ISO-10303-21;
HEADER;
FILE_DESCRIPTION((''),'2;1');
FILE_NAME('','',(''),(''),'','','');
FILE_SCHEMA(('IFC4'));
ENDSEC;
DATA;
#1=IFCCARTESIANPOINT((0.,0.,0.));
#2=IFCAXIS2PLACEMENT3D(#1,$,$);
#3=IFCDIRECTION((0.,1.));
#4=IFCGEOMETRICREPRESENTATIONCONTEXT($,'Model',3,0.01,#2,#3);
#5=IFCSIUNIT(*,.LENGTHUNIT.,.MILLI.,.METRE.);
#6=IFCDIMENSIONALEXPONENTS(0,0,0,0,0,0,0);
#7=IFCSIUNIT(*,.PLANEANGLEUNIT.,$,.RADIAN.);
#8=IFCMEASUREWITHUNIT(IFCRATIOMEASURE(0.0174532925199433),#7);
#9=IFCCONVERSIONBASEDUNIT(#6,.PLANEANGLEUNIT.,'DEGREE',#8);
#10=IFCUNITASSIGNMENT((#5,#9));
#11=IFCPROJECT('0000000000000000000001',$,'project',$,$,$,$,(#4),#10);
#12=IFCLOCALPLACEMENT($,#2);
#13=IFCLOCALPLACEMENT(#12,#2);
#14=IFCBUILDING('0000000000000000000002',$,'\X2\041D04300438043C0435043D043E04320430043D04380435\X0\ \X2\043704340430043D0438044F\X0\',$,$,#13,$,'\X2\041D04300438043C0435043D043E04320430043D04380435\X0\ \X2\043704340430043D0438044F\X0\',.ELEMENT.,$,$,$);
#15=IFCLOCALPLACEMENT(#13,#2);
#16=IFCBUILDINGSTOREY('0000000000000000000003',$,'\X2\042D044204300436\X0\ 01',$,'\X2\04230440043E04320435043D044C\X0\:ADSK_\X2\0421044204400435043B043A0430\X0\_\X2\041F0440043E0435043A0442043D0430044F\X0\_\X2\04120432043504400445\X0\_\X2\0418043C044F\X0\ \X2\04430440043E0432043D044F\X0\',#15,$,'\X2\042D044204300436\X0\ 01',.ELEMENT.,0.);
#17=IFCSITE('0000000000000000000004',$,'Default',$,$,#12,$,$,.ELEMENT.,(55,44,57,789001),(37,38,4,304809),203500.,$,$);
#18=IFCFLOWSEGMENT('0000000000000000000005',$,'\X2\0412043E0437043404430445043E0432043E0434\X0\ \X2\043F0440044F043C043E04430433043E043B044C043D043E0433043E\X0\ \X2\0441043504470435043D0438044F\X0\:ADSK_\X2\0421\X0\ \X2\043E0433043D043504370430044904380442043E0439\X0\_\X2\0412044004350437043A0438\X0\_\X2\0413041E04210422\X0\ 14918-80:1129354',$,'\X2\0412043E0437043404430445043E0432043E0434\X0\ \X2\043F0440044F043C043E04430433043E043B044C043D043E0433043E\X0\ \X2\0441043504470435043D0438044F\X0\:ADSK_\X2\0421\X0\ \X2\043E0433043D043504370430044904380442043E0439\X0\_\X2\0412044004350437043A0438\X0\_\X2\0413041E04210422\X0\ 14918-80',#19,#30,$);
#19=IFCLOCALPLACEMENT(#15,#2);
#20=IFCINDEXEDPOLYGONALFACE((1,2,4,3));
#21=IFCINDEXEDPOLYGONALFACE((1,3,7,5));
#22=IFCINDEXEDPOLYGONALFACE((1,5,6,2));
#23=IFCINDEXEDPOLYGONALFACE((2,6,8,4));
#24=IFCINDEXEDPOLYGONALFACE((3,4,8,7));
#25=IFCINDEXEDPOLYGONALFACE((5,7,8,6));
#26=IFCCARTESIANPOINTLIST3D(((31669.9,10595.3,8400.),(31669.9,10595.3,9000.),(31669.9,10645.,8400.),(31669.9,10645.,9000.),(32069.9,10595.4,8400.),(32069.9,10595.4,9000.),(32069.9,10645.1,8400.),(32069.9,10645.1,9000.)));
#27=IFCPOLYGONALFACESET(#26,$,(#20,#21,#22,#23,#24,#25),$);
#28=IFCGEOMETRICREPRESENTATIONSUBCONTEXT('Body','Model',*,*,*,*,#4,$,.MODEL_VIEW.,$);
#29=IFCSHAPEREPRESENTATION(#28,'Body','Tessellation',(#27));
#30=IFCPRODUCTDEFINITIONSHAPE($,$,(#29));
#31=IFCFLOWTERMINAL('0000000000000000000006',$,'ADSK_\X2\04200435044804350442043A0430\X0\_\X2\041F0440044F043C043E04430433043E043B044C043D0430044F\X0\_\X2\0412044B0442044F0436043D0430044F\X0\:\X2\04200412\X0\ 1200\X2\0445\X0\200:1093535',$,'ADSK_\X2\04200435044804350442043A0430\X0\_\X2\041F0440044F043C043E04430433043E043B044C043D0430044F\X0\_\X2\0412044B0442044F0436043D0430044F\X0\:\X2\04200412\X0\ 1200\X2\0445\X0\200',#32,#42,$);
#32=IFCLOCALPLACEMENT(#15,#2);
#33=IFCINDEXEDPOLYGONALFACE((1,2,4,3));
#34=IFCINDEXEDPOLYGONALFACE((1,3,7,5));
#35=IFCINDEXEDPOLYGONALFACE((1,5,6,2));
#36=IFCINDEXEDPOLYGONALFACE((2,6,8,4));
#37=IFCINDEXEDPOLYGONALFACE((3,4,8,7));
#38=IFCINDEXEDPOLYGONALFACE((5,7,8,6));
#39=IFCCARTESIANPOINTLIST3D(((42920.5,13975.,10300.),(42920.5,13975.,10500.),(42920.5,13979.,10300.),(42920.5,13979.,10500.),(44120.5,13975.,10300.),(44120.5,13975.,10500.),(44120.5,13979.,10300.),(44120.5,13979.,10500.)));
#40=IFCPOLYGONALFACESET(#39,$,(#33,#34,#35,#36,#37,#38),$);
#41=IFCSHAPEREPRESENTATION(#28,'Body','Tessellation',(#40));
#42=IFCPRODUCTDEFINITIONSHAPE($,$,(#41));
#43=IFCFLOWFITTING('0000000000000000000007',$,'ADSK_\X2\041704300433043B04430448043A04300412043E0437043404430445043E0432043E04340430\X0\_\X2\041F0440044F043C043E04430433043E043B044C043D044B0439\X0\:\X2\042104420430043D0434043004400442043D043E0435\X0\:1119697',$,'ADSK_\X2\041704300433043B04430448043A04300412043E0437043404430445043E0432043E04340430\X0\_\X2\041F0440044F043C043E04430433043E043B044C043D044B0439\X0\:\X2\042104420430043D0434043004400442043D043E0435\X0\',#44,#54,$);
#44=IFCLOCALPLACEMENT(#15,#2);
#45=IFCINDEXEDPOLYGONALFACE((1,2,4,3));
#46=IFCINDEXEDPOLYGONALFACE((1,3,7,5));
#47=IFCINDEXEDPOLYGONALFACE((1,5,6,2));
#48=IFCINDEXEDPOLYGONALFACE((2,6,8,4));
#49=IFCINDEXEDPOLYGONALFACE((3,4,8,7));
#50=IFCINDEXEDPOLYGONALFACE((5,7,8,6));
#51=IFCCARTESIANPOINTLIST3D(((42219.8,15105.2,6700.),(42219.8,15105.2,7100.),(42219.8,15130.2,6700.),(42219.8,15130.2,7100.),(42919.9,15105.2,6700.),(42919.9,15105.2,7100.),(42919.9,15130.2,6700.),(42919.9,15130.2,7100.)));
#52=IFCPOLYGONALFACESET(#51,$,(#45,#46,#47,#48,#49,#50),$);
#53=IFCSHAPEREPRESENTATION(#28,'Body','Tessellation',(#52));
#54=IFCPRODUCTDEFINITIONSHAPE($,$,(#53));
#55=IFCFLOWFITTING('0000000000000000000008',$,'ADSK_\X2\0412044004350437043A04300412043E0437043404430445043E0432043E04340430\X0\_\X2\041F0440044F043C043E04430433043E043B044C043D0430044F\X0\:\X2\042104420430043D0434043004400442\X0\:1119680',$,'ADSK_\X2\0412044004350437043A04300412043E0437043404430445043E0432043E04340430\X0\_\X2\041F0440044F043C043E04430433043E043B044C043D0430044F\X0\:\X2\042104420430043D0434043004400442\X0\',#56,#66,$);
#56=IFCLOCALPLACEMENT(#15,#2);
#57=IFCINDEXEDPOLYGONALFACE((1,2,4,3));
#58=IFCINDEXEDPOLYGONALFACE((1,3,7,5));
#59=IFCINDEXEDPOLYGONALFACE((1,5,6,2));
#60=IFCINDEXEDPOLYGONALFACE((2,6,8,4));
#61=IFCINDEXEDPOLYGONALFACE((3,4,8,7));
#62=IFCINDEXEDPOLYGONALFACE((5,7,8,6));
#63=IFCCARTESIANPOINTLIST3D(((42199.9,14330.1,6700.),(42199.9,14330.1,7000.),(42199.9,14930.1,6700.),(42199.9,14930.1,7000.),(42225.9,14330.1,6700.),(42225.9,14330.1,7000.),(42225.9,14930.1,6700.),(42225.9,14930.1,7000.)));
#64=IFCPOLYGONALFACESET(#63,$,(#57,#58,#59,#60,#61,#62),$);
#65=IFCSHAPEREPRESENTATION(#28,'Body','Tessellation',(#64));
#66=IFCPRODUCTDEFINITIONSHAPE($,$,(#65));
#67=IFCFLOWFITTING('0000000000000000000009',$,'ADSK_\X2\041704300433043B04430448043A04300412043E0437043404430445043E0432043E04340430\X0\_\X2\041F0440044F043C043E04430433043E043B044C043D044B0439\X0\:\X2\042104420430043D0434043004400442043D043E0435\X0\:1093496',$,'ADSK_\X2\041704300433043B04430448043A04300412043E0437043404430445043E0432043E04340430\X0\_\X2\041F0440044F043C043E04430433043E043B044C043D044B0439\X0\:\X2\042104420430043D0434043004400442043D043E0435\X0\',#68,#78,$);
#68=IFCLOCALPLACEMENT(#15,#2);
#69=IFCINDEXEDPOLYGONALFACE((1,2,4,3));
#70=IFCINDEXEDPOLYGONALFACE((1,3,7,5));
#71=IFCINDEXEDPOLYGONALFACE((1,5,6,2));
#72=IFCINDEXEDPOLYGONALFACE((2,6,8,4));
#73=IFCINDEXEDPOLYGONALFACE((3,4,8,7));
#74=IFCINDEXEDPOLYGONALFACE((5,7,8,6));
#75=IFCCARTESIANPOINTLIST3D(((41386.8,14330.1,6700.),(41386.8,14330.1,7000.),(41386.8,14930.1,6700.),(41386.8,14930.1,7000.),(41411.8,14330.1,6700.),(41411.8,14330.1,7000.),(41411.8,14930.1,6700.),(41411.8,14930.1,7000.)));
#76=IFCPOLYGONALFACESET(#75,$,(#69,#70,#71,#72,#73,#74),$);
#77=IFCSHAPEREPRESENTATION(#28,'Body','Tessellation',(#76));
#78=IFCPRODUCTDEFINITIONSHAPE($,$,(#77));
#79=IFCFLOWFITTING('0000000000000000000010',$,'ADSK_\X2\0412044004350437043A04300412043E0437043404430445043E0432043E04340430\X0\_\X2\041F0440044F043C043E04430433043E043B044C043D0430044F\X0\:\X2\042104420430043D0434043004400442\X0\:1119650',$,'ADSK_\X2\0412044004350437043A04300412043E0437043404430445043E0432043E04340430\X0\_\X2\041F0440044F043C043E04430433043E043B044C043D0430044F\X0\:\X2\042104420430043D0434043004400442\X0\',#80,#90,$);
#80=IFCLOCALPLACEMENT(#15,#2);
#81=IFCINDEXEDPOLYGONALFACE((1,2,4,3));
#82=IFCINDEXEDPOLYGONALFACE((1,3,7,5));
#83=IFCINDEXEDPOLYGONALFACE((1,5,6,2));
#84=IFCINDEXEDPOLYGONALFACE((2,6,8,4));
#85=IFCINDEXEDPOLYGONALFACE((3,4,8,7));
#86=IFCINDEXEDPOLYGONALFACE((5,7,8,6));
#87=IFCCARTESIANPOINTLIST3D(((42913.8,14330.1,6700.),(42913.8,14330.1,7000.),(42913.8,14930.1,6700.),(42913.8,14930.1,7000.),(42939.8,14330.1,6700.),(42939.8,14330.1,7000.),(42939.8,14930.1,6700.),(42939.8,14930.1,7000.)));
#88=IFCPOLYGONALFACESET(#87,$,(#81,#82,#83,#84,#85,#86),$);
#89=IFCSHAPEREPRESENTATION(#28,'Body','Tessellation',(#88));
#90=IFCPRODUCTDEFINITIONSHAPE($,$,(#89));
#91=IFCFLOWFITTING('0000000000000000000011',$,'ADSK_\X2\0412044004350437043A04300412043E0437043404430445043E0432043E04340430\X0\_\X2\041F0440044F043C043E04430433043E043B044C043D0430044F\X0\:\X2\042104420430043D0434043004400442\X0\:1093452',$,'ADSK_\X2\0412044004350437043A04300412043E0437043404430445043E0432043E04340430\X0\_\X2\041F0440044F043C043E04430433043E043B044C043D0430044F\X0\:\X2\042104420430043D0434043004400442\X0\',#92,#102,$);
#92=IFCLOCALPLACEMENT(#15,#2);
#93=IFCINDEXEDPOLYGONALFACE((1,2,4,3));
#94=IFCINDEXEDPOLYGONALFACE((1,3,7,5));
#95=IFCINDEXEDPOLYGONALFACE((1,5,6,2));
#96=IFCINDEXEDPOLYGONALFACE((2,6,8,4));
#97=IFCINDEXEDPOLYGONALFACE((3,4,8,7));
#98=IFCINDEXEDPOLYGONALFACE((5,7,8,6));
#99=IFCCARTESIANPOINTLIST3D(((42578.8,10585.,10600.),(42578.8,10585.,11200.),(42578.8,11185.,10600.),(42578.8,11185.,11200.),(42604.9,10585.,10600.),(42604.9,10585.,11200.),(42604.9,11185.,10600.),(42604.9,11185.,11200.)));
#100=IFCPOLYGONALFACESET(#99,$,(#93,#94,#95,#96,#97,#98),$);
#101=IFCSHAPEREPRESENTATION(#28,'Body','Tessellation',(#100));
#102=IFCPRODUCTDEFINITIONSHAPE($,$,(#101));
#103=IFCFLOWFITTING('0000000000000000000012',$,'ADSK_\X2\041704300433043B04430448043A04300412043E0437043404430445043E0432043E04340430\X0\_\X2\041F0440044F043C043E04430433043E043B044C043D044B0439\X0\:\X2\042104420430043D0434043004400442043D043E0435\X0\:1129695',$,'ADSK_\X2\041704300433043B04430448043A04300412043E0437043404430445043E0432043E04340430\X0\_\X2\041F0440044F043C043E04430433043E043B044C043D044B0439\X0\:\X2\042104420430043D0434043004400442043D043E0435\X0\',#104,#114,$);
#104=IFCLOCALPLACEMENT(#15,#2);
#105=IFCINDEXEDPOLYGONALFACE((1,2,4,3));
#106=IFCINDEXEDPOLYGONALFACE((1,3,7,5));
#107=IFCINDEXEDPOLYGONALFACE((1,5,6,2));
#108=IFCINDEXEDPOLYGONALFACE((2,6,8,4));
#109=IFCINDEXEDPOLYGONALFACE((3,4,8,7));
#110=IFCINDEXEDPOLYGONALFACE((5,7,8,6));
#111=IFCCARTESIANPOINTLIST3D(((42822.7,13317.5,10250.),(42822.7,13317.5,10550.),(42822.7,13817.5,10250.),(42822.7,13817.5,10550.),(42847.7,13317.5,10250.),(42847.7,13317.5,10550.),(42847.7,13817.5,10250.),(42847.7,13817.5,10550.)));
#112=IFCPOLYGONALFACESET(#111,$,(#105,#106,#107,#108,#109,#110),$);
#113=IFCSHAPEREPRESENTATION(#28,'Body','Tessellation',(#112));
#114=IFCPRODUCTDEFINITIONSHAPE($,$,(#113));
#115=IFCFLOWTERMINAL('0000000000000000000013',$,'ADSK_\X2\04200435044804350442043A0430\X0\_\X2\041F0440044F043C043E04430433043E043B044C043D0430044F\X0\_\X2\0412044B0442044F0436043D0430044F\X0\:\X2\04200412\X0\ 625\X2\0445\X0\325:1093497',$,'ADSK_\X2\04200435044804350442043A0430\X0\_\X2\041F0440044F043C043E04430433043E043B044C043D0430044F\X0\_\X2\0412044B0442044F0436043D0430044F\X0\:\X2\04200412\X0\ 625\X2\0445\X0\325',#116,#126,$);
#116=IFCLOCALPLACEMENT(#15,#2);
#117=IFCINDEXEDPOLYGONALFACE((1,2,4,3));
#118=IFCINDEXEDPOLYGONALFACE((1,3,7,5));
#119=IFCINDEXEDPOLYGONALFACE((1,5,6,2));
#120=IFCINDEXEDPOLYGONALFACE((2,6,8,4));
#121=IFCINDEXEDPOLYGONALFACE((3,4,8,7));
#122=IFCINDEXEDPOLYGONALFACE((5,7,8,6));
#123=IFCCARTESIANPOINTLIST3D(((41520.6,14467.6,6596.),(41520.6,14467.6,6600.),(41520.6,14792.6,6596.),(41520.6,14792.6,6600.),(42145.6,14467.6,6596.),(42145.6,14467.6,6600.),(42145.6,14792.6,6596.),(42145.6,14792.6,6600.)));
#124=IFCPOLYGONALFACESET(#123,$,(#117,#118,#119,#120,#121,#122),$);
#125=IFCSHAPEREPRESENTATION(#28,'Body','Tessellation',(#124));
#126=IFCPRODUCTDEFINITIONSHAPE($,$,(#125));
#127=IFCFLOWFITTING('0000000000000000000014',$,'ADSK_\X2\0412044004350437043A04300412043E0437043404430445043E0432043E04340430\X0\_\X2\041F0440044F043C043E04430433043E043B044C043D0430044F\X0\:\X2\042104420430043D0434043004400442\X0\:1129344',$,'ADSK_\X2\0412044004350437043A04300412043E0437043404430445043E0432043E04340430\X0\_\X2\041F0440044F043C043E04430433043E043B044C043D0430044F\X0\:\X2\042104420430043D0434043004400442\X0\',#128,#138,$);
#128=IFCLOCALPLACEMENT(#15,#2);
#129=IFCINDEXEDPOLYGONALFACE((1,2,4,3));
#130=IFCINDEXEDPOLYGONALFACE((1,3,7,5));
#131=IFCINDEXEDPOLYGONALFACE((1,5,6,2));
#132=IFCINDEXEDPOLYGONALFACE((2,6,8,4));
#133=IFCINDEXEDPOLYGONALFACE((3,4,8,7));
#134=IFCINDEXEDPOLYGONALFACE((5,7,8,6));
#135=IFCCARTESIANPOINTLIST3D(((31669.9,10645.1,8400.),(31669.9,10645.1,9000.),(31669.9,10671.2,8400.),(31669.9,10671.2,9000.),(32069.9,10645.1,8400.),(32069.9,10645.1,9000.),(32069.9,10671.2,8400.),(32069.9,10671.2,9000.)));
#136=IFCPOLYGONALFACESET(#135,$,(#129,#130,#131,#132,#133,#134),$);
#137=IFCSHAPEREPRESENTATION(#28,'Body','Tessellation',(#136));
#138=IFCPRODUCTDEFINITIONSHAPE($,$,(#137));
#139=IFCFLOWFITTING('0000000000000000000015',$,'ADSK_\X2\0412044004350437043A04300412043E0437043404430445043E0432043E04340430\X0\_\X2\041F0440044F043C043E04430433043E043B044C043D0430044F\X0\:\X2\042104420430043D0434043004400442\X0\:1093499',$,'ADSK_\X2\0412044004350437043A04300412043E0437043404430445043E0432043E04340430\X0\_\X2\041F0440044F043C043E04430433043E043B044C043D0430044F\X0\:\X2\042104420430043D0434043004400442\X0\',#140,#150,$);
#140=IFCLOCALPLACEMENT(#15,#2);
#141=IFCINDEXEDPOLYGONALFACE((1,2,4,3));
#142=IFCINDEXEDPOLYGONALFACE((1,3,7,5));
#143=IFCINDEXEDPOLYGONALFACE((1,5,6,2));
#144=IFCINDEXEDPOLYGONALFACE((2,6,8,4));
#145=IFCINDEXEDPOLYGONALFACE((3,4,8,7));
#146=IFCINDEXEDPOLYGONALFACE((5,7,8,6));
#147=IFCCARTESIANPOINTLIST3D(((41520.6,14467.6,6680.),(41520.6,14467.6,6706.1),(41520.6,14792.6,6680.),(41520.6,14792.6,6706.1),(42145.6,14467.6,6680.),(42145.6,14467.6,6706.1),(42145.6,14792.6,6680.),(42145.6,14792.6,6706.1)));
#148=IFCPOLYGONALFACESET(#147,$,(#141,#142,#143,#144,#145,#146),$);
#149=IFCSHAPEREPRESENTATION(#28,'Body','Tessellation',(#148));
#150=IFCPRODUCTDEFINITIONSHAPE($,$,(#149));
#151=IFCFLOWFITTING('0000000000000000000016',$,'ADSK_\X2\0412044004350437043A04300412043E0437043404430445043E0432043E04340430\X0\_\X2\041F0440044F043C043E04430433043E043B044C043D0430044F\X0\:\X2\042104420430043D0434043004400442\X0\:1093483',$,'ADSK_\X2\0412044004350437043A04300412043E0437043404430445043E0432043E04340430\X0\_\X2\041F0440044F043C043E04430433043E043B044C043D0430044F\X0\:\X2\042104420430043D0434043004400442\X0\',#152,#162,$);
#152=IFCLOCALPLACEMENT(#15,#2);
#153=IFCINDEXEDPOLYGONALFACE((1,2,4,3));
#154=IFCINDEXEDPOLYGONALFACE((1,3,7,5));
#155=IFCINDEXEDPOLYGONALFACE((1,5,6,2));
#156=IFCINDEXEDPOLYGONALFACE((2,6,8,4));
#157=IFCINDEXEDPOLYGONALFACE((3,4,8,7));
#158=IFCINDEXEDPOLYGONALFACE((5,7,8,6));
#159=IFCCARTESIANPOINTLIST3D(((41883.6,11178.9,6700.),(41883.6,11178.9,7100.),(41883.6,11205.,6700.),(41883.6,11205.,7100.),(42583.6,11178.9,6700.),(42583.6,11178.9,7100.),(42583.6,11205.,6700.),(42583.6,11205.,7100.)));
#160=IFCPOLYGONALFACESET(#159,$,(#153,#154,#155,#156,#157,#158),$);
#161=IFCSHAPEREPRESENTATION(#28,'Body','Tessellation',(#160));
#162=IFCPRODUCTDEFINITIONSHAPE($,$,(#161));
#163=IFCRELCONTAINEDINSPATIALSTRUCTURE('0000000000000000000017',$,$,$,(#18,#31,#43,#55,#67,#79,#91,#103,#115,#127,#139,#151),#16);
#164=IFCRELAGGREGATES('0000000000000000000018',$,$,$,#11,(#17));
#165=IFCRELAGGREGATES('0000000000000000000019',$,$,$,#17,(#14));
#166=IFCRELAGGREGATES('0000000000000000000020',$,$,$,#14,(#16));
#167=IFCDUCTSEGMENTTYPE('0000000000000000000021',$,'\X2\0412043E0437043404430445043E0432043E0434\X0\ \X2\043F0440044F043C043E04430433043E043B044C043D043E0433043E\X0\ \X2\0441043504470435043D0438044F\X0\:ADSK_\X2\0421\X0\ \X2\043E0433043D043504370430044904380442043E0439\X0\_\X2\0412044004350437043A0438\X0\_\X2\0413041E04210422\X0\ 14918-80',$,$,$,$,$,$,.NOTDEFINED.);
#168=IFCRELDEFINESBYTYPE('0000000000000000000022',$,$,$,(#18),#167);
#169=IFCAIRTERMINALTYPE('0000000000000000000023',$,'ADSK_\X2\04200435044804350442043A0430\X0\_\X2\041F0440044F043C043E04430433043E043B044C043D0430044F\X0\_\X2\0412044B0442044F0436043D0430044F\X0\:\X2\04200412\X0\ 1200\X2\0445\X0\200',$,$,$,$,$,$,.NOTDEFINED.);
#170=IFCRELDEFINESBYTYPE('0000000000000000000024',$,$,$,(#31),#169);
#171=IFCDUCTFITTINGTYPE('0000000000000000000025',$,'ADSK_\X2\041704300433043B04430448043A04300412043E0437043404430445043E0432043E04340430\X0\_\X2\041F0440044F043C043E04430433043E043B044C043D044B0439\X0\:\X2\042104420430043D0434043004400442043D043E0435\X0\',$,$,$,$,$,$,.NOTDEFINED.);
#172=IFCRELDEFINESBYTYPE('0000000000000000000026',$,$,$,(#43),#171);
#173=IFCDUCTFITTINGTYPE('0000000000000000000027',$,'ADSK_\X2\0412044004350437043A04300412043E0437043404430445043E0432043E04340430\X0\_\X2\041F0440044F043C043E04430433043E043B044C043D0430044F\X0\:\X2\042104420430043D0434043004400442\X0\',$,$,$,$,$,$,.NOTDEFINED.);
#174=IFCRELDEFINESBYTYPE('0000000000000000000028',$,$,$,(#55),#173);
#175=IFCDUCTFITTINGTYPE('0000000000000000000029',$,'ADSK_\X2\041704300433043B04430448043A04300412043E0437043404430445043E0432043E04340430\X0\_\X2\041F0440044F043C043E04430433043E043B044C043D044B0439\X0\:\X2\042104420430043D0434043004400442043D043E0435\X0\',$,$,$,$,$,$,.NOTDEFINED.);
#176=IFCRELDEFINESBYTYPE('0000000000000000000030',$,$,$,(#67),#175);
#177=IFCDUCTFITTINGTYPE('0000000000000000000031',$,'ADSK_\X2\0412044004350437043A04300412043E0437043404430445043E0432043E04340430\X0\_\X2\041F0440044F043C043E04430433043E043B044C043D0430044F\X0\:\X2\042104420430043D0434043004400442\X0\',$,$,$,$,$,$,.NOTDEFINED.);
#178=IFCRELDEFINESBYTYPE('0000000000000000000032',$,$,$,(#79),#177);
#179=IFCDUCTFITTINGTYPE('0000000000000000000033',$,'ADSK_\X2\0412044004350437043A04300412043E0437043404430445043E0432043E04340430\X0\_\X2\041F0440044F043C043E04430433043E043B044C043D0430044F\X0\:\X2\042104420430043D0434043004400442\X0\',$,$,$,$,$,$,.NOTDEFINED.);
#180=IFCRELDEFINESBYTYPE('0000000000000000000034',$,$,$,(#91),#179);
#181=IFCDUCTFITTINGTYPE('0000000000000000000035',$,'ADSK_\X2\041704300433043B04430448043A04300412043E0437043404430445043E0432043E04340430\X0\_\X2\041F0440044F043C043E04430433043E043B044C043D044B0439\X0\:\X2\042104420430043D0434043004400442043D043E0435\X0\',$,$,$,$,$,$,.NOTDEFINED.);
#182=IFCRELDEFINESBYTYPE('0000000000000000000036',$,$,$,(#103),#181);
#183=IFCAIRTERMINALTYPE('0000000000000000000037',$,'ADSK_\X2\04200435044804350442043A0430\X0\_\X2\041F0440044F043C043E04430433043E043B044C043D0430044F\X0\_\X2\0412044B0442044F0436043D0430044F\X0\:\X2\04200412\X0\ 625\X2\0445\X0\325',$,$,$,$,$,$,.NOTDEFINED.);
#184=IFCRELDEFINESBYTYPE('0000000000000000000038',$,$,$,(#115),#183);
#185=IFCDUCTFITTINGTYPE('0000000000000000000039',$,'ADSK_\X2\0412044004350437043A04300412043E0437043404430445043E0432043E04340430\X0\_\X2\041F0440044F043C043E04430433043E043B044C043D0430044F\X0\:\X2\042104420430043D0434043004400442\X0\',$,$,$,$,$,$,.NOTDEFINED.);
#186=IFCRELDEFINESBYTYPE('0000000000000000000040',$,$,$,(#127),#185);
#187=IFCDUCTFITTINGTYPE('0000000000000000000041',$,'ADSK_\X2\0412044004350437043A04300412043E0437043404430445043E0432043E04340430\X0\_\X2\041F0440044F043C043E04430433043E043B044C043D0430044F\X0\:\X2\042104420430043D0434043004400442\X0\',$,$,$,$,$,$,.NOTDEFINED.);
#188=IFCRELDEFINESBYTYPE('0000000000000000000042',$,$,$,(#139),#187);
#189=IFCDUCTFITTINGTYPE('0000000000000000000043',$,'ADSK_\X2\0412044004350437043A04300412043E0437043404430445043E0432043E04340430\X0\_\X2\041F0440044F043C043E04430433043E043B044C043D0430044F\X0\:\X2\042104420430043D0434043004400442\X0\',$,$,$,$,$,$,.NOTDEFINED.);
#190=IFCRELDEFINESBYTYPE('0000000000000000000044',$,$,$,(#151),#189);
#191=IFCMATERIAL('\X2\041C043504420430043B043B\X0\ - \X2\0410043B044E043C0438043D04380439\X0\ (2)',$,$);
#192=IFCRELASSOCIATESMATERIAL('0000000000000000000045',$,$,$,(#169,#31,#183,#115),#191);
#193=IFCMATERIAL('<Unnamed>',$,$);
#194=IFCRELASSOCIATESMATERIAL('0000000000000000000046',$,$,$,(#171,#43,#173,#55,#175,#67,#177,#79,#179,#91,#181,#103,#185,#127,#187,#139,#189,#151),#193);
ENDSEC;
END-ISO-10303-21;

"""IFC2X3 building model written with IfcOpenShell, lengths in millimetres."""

from ifc_helpers import new_model, entity, si_unit, converted_unit, direction, frame, origin, origin_2d_with_axis, place, context, subcontext, project, spatial, rectangle, extrude, source, transform, mapped, material, type_object, type_shapes, element, save


model = new_model("IFC2X3")

# Units and contexts
model_context = context("Model", 3, precision=0.01, world=origin(), true_north=direction((0.0, 1.0)))
body_context = subcontext(model_context, "Body", "Model", "MODEL_VIEW")
ifc_project = project(units=[si_unit("LENGTHUNIT", "METRE", prefix="MILLI"), converted_unit("PLANEANGLEUNIT", "DEGREE", entity("IfcRatioMeasure", 0.0174532925199433), si_unit("PLANEANGLEUNIT", "RADIAN"), dimensions=[0, 0, 0, 0, 0, 0, 0])], contexts=[model_context])

# Site, building, storey
site_placement = place(None, origin())
site = spatial("IfcSite", under=ifc_project, at=site_placement, Name="Default", CompositionType="ELEMENT", RefLatitude=(55, 44, 57, 789001), RefLongitude=(37, 38, 4, 304809), RefElevation=203500.0)
building_placement = place(site_placement, origin())
building = spatial("IfcBuilding", under=site, at=building_placement, Name="Наименование здания", LongName="Наименование здания", CompositionType="ELEMENT")
storey_placement = place(building_placement, origin())
storey = spatial("IfcBuildingStorey", under=building, at=storey_placement, Name="Этаж 01", ObjectType="Уровень:ADSK_Стрелка_Проектная_Вверх_Имя уровня", LongName="Этаж 01", CompositionType="ELEMENT", Elevation=0.0)

# Flow segment
duct_segment_type = type_object("IfcDuctSegmentType", Name="Воздуховод прямоугольного сечения:ADSK_С огнезащитой_Врезки_ГОСТ 14918-80", PredefinedType="NOTDEFINED")
flow_segment_1_placement = place(storey_placement, frame((31669.9, 10595.3, 8400.0)))
element("IfcFlowSegment", 1, at=flow_segment_1_placement, inside=storey, type_object=duct_segment_type, Name="Воздуховод прямоугольного сечения:ADSK_С огнезащитой_Врезки_ГОСТ 14918-80:1129354", ObjectType="Воздуховод прямоугольного сечения:ADSK_С огнезащитой_Врезки_ГОСТ 14918-80", context=body_context, shape_type="SweptSolid", body=[
    extrude(rectangle(XDim=49.7, YDim=400.0, at=origin_2d_with_axis()), frame((200.0, 24.9, 0.0), z_axis=(0.0, 0.0, 1.0), x_axis=(-0.000236, 1.0, 0.0)), (0.0, 0.0, 1.0), 600.0),
])

# Flow terminal
ifc_material_1 = material(Name="Металл - Алюминий (2)")
air_terminal_type_1 = type_object("IfcAirTerminalType", Name="ADSK_Решетка_Прямоугольная_Вытяжная:РВ 1200х200", PredefinedType="NOTDEFINED", material=ifc_material_1)
shared_shape_1 = source(origin(), body_context, "Body", "SweptSolid", [
    extrude(rectangle(XDim=4.0, YDim=1200.0, at=origin_2d_with_axis()), frame((0.0, -2.0, -100.0), z_axis=(0.0, 0.0, 1.0), x_axis=(0.0, 1.0, 0.0)), (0.0, 0.0, 1.0), 200.0),
])
type_shapes(air_terminal_type_1, [shared_shape_1])
flow_terminal_1_placement = place(storey_placement, frame((43520.5, 13975.0, 10400.0), z_axis=(0.0, 0.0, 1.0), x_axis=(-1.0, 0.0, 0.0)))
element("IfcFlowTerminal", 2, at=flow_terminal_1_placement, inside=storey, type_object=air_terminal_type_1, material=ifc_material_1, Name="ADSK_Решетка_Прямоугольная_Вытяжная:РВ 1200х200:1093535", ObjectType="ADSK_Решетка_Прямоугольная_Вытяжная:РВ 1200х200", context=body_context, shape_type="MappedRepresentation", body=[
    mapped(shared_shape_1, transform((0.0, 0.0, 0.0), scale=1.0)),
])

# Flow fittings
ifc_material_2 = material(Name="<Unnamed>")
duct_fitting_type_1 = type_object("IfcDuctFittingType", Name="ADSK_ЗаглушкаВоздуховода_Прямоугольный:Стандартное", PredefinedType="NOTDEFINED", material=ifc_material_2)
shared_shape_2 = source(origin(), body_context, "Body", "SweptSolid", [
    extrude(rectangle(XDim=25.0, YDim=700.0, at=origin_2d_with_axis()), frame((12.5, 0.0, -200.0)), (0.0, 0.0, 1.0), 400.0),
])
type_shapes(duct_fitting_type_1, [shared_shape_2])
flow_fitting_1_placement = place(storey_placement, frame((42569.8, 15105.2, 6900.0), z_axis=(0.0, 0.0, 1.0), x_axis=(0.0, 1.0, 0.0)))
element("IfcFlowFitting", 3, at=flow_fitting_1_placement, inside=storey, type_object=duct_fitting_type_1, material=ifc_material_2, Name="ADSK_ЗаглушкаВоздуховода_Прямоугольный:Стандартное:1119697", ObjectType="ADSK_ЗаглушкаВоздуховода_Прямоугольный:Стандартное", context=body_context, shape_type="MappedRepresentation", body=[
    mapped(shared_shape_2, transform((0.0, 0.0, 0.0), scale=1.0)),
])
duct_fitting_type_2 = type_object("IfcDuctFittingType", Name="ADSK_ВрезкаВоздуховода_Прямоугольная:Стандарт", PredefinedType="NOTDEFINED", material=ifc_material_2)
shared_shape_3 = source(origin(), body_context, "Body", "SweptSolid", [
    extrude(rectangle(XDim=26.1, YDim=600.0, at=origin_2d_with_axis()), frame((7.0, 0.0, -150.0)), (0.0, 0.0, 1.0), 300.0),
])
type_shapes(duct_fitting_type_2, [shared_shape_3])
flow_fitting_2_placement = place(storey_placement, frame((42219.8, 14630.1, 6850.0), z_axis=(0.0, 0.0, -1.0), x_axis=(-1.0, 0.0, 0.0)))
element("IfcFlowFitting", 4, at=flow_fitting_2_placement, inside=storey, type_object=duct_fitting_type_2, material=ifc_material_2, Name="ADSK_ВрезкаВоздуховода_Прямоугольная:Стандарт:1119680", ObjectType="ADSK_ВрезкаВоздуховода_Прямоугольная:Стандарт", context=body_context, shape_type="MappedRepresentation", body=[
    mapped(shared_shape_3, transform((0.0, 0.0, 0.0), scale=1.0)),
])
duct_fitting_type_3 = type_object("IfcDuctFittingType", Name="ADSK_ЗаглушкаВоздуховода_Прямоугольный:Стандартное", PredefinedType="NOTDEFINED", material=ifc_material_2)
shared_shape_4 = source(origin(), body_context, "Body", "SweptSolid", [
    extrude(rectangle(XDim=25.0, YDim=600.0, at=origin_2d_with_axis()), frame((12.5, 0.0, -150.0)), (0.0, 0.0, 1.0), 300.0),
])
type_shapes(duct_fitting_type_3, [shared_shape_4])
flow_fitting_3_placement = place(storey_placement, frame((41411.8, 14630.1, 6850.0), z_axis=(0.0, 0.0, 1.0), x_axis=(-1.0, 0.0, 0.0)))
element("IfcFlowFitting", 5, at=flow_fitting_3_placement, inside=storey, type_object=duct_fitting_type_3, material=ifc_material_2, Name="ADSK_ЗаглушкаВоздуховода_Прямоугольный:Стандартное:1093496", ObjectType="ADSK_ЗаглушкаВоздуховода_Прямоугольный:Стандартное", context=body_context, shape_type="MappedRepresentation", body=[
    mapped(shared_shape_4, transform((0.0, 0.0, 0.0), scale=1.0)),
])
duct_fitting_type_4 = type_object("IfcDuctFittingType", Name="ADSK_ВрезкаВоздуховода_Прямоугольная:Стандарт", PredefinedType="NOTDEFINED", material=ifc_material_2)
shared_shape_5 = source(origin(), body_context, "Body", "SweptSolid", [
    extrude(rectangle(XDim=600.0, YDim=26.1, at=origin_2d_with_axis()), frame((7.0, 0.0, -150.0), z_axis=(0.0, 0.0, 1.0), x_axis=(0.0, -1.0, 0.0)), (0.0, 0.0, 1.0), 300.0),
])
type_shapes(duct_fitting_type_4, [shared_shape_5])
flow_fitting_4_placement = place(storey_placement, frame((42919.8, 14630.1, 6850.0), z_axis=(0.0, 0.0, -1.0), x_axis=(1.0, 0.0, 0.0)))
element("IfcFlowFitting", 6, at=flow_fitting_4_placement, inside=storey, type_object=duct_fitting_type_4, material=ifc_material_2, Name="ADSK_ВрезкаВоздуховода_Прямоугольная:Стандарт:1119650", ObjectType="ADSK_ВрезкаВоздуховода_Прямоугольная:Стандарт", context=body_context, shape_type="MappedRepresentation", body=[
    mapped(shared_shape_5, transform((0.0, 0.0, 0.0), scale=1.0)),
])
duct_fitting_type_5 = type_object("IfcDuctFittingType", Name="ADSK_ВрезкаВоздуховода_Прямоугольная:Стандарт", PredefinedType="NOTDEFINED", material=ifc_material_2)
shared_shape_6 = source(origin(), body_context, "Body", "SweptSolid", [
    extrude(rectangle(XDim=600.0, YDim=26.1, at=origin_2d_with_axis()), frame((7.0, 0.0, -300.0), z_axis=(0.0, 0.0, 1.0), x_axis=(0.0, -1.0, 0.0)), (0.0, 0.0, 1.0), 600.0),
])
type_shapes(duct_fitting_type_5, [shared_shape_6])
flow_fitting_5_placement = place(storey_placement, frame((42584.9, 10885.0, 10900.0), z_axis=(0.0, -1.0, 0.0), x_axis=(1.0, 0.0, 0.0)))
element("IfcFlowFitting", 7, at=flow_fitting_5_placement, inside=storey, type_object=duct_fitting_type_5, material=ifc_material_2, Name="ADSK_ВрезкаВоздуховода_Прямоугольная:Стандарт:1093452", ObjectType="ADSK_ВрезкаВоздуховода_Прямоугольная:Стандарт", context=body_context, shape_type="MappedRepresentation", body=[
    mapped(shared_shape_6, transform((0.0, 0.0, 0.0), scale=1.0)),
])
duct_fitting_type_6 = type_object("IfcDuctFittingType", Name="ADSK_ЗаглушкаВоздуховода_Прямоугольный:Стандартное", PredefinedType="NOTDEFINED", material=ifc_material_2)
shared_shape_7 = source(origin(), body_context, "Body", "SweptSolid", [
    extrude(rectangle(XDim=25.0, YDim=500.0, at=origin_2d_with_axis()), frame((12.5, 0.0, -150.0)), (0.0, 0.0, 1.0), 300.0),
])
type_shapes(duct_fitting_type_6, [shared_shape_7])
flow_fitting_6_placement = place(storey_placement, frame((42847.7, 13567.5, 10400.0), z_axis=(0.0, 0.0, 1.0), x_axis=(-1.0, 0.0, 0.0)))
element("IfcFlowFitting", 8, at=flow_fitting_6_placement, inside=storey, type_object=duct_fitting_type_6, material=ifc_material_2, Name="ADSK_ЗаглушкаВоздуховода_Прямоугольный:Стандартное:1129695", ObjectType="ADSK_ЗаглушкаВоздуховода_Прямоугольный:Стандартное", context=body_context, shape_type="MappedRepresentation", body=[
    mapped(shared_shape_7, transform((0.0, 0.0, 0.0), scale=1.0)),
])

# Flow terminal
air_terminal_type_2 = type_object("IfcAirTerminalType", Name="ADSK_Решетка_Прямоугольная_Вытяжная:РВ 625х325", PredefinedType="NOTDEFINED", material=ifc_material_1)
shared_shape_8 = source(origin(), body_context, "Body", "SweptSolid", [
    extrude(rectangle(XDim=4.0, YDim=625.0, at=origin_2d_with_axis()), frame((0.0, -2.0, -162.5), z_axis=(0.0, 0.0, 1.0), x_axis=(0.0, 1.0, 0.0)), (0.0, 0.0, 1.0), 325.0),
])
type_shapes(air_terminal_type_2, [shared_shape_8])
flow_terminal_2_placement = place(storey_placement, frame((41833.1, 14630.1, 6600.0), z_axis=(0.0, 1.0, 0.0), x_axis=(-1.0, 0.0, 0.0)))
element("IfcFlowTerminal", 9, at=flow_terminal_2_placement, inside=storey, type_object=air_terminal_type_2, material=ifc_material_1, Name="ADSK_Решетка_Прямоугольная_Вытяжная:РВ 625х325:1093497", ObjectType="ADSK_Решетка_Прямоугольная_Вытяжная:РВ 625х325", context=body_context, shape_type="MappedRepresentation", body=[
    mapped(shared_shape_8, transform((0.0, 0.0, 0.0), scale=1.0)),
])

# Flow fittings
duct_fitting_type_7 = type_object("IfcDuctFittingType", Name="ADSK_ВрезкаВоздуховода_Прямоугольная:Стандарт", PredefinedType="NOTDEFINED", material=ifc_material_2)
shared_shape_9 = source(origin(), body_context, "Body", "SweptSolid", [
    extrude(rectangle(XDim=600.0, YDim=26.1, at=origin_2d_with_axis()), frame((7.0, 0.0, -200.0), z_axis=(0.0, 0.0, 1.0), x_axis=(0.0, -1.0, 0.0)), (0.0, 0.0, 1.0), 400.0),
])
type_shapes(duct_fitting_type_7, [shared_shape_9])
flow_fitting_7_placement = place(storey_placement, frame((31869.9, 10665.1, 8700.0), z_axis=(-1.0, 0.0, 0.0), x_axis=(0.0, -1.0, 0.0)))
element("IfcFlowFitting", 10, at=flow_fitting_7_placement, inside=storey, type_object=duct_fitting_type_7, material=ifc_material_2, Name="ADSK_ВрезкаВоздуховода_Прямоугольная:Стандарт:1129344", ObjectType="ADSK_ВрезкаВоздуховода_Прямоугольная:Стандарт", context=body_context, shape_type="MappedRepresentation", body=[
    mapped(shared_shape_9, transform((0.0, 0.0, 0.0), scale=1.0)),
])
duct_fitting_type_8 = type_object("IfcDuctFittingType", Name="ADSK_ВрезкаВоздуховода_Прямоугольная:Стандарт", PredefinedType="NOTDEFINED", material=ifc_material_2)
shared_shape_10 = source(origin(), body_context, "Body", "SweptSolid", [
    extrude(rectangle(XDim=26.1, YDim=625.0, at=origin_2d_with_axis()), frame((7.0, 0.0, -162.5)), (0.0, 0.0, 1.0), 325.0),
])
type_shapes(duct_fitting_type_8, [shared_shape_10])
flow_fitting_8_placement = place(storey_placement, frame((41833.1, 14630.1, 6700.0), z_axis=(0.0, -1.0, 0.0), x_axis=(0.0, 0.0, -1.0)))
element("IfcFlowFitting", 11, at=flow_fitting_8_placement, inside=storey, type_object=duct_fitting_type_8, material=ifc_material_2, Name="ADSK_ВрезкаВоздуховода_Прямоугольная:Стандарт:1093499", ObjectType="ADSK_ВрезкаВоздуховода_Прямоугольная:Стандарт", context=body_context, shape_type="MappedRepresentation", body=[
    mapped(shared_shape_10, transform((0.0, 0.0, 0.0), scale=1.0)),
])
duct_fitting_type_9 = type_object("IfcDuctFittingType", Name="ADSK_ВрезкаВоздуховода_Прямоугольная:Стандарт", PredefinedType="NOTDEFINED", material=ifc_material_2)
shared_shape_11 = source(origin(), body_context, "Body", "SweptSolid", [
    extrude(rectangle(XDim=400.0, YDim=26.1, at=origin_2d_with_axis()), frame((7.0, 0.0, -350.0), z_axis=(0.0, 0.0, 1.0), x_axis=(0.0, -1.0, 0.0)), (0.0, 0.0, 1.0), 700.0),
])
type_shapes(duct_fitting_type_9, [shared_shape_11])
flow_fitting_9_placement = place(storey_placement, frame((42233.6, 11185.0, 6900.0), z_axis=(1.0, 0.0, 0.0), x_axis=(0.0, 1.0, 0.0)))
element("IfcFlowFitting", 12, at=flow_fitting_9_placement, inside=storey, type_object=duct_fitting_type_9, material=ifc_material_2, Name="ADSK_ВрезкаВоздуховода_Прямоугольная:Стандарт:1093483", ObjectType="ADSK_ВрезкаВоздуховода_Прямоугольная:Стандарт", context=body_context, shape_type="MappedRepresentation", body=[
    mapped(shared_shape_11, transform((0.0, 0.0, 0.0), scale=1.0)),
])

save(model, "model.ifc")
